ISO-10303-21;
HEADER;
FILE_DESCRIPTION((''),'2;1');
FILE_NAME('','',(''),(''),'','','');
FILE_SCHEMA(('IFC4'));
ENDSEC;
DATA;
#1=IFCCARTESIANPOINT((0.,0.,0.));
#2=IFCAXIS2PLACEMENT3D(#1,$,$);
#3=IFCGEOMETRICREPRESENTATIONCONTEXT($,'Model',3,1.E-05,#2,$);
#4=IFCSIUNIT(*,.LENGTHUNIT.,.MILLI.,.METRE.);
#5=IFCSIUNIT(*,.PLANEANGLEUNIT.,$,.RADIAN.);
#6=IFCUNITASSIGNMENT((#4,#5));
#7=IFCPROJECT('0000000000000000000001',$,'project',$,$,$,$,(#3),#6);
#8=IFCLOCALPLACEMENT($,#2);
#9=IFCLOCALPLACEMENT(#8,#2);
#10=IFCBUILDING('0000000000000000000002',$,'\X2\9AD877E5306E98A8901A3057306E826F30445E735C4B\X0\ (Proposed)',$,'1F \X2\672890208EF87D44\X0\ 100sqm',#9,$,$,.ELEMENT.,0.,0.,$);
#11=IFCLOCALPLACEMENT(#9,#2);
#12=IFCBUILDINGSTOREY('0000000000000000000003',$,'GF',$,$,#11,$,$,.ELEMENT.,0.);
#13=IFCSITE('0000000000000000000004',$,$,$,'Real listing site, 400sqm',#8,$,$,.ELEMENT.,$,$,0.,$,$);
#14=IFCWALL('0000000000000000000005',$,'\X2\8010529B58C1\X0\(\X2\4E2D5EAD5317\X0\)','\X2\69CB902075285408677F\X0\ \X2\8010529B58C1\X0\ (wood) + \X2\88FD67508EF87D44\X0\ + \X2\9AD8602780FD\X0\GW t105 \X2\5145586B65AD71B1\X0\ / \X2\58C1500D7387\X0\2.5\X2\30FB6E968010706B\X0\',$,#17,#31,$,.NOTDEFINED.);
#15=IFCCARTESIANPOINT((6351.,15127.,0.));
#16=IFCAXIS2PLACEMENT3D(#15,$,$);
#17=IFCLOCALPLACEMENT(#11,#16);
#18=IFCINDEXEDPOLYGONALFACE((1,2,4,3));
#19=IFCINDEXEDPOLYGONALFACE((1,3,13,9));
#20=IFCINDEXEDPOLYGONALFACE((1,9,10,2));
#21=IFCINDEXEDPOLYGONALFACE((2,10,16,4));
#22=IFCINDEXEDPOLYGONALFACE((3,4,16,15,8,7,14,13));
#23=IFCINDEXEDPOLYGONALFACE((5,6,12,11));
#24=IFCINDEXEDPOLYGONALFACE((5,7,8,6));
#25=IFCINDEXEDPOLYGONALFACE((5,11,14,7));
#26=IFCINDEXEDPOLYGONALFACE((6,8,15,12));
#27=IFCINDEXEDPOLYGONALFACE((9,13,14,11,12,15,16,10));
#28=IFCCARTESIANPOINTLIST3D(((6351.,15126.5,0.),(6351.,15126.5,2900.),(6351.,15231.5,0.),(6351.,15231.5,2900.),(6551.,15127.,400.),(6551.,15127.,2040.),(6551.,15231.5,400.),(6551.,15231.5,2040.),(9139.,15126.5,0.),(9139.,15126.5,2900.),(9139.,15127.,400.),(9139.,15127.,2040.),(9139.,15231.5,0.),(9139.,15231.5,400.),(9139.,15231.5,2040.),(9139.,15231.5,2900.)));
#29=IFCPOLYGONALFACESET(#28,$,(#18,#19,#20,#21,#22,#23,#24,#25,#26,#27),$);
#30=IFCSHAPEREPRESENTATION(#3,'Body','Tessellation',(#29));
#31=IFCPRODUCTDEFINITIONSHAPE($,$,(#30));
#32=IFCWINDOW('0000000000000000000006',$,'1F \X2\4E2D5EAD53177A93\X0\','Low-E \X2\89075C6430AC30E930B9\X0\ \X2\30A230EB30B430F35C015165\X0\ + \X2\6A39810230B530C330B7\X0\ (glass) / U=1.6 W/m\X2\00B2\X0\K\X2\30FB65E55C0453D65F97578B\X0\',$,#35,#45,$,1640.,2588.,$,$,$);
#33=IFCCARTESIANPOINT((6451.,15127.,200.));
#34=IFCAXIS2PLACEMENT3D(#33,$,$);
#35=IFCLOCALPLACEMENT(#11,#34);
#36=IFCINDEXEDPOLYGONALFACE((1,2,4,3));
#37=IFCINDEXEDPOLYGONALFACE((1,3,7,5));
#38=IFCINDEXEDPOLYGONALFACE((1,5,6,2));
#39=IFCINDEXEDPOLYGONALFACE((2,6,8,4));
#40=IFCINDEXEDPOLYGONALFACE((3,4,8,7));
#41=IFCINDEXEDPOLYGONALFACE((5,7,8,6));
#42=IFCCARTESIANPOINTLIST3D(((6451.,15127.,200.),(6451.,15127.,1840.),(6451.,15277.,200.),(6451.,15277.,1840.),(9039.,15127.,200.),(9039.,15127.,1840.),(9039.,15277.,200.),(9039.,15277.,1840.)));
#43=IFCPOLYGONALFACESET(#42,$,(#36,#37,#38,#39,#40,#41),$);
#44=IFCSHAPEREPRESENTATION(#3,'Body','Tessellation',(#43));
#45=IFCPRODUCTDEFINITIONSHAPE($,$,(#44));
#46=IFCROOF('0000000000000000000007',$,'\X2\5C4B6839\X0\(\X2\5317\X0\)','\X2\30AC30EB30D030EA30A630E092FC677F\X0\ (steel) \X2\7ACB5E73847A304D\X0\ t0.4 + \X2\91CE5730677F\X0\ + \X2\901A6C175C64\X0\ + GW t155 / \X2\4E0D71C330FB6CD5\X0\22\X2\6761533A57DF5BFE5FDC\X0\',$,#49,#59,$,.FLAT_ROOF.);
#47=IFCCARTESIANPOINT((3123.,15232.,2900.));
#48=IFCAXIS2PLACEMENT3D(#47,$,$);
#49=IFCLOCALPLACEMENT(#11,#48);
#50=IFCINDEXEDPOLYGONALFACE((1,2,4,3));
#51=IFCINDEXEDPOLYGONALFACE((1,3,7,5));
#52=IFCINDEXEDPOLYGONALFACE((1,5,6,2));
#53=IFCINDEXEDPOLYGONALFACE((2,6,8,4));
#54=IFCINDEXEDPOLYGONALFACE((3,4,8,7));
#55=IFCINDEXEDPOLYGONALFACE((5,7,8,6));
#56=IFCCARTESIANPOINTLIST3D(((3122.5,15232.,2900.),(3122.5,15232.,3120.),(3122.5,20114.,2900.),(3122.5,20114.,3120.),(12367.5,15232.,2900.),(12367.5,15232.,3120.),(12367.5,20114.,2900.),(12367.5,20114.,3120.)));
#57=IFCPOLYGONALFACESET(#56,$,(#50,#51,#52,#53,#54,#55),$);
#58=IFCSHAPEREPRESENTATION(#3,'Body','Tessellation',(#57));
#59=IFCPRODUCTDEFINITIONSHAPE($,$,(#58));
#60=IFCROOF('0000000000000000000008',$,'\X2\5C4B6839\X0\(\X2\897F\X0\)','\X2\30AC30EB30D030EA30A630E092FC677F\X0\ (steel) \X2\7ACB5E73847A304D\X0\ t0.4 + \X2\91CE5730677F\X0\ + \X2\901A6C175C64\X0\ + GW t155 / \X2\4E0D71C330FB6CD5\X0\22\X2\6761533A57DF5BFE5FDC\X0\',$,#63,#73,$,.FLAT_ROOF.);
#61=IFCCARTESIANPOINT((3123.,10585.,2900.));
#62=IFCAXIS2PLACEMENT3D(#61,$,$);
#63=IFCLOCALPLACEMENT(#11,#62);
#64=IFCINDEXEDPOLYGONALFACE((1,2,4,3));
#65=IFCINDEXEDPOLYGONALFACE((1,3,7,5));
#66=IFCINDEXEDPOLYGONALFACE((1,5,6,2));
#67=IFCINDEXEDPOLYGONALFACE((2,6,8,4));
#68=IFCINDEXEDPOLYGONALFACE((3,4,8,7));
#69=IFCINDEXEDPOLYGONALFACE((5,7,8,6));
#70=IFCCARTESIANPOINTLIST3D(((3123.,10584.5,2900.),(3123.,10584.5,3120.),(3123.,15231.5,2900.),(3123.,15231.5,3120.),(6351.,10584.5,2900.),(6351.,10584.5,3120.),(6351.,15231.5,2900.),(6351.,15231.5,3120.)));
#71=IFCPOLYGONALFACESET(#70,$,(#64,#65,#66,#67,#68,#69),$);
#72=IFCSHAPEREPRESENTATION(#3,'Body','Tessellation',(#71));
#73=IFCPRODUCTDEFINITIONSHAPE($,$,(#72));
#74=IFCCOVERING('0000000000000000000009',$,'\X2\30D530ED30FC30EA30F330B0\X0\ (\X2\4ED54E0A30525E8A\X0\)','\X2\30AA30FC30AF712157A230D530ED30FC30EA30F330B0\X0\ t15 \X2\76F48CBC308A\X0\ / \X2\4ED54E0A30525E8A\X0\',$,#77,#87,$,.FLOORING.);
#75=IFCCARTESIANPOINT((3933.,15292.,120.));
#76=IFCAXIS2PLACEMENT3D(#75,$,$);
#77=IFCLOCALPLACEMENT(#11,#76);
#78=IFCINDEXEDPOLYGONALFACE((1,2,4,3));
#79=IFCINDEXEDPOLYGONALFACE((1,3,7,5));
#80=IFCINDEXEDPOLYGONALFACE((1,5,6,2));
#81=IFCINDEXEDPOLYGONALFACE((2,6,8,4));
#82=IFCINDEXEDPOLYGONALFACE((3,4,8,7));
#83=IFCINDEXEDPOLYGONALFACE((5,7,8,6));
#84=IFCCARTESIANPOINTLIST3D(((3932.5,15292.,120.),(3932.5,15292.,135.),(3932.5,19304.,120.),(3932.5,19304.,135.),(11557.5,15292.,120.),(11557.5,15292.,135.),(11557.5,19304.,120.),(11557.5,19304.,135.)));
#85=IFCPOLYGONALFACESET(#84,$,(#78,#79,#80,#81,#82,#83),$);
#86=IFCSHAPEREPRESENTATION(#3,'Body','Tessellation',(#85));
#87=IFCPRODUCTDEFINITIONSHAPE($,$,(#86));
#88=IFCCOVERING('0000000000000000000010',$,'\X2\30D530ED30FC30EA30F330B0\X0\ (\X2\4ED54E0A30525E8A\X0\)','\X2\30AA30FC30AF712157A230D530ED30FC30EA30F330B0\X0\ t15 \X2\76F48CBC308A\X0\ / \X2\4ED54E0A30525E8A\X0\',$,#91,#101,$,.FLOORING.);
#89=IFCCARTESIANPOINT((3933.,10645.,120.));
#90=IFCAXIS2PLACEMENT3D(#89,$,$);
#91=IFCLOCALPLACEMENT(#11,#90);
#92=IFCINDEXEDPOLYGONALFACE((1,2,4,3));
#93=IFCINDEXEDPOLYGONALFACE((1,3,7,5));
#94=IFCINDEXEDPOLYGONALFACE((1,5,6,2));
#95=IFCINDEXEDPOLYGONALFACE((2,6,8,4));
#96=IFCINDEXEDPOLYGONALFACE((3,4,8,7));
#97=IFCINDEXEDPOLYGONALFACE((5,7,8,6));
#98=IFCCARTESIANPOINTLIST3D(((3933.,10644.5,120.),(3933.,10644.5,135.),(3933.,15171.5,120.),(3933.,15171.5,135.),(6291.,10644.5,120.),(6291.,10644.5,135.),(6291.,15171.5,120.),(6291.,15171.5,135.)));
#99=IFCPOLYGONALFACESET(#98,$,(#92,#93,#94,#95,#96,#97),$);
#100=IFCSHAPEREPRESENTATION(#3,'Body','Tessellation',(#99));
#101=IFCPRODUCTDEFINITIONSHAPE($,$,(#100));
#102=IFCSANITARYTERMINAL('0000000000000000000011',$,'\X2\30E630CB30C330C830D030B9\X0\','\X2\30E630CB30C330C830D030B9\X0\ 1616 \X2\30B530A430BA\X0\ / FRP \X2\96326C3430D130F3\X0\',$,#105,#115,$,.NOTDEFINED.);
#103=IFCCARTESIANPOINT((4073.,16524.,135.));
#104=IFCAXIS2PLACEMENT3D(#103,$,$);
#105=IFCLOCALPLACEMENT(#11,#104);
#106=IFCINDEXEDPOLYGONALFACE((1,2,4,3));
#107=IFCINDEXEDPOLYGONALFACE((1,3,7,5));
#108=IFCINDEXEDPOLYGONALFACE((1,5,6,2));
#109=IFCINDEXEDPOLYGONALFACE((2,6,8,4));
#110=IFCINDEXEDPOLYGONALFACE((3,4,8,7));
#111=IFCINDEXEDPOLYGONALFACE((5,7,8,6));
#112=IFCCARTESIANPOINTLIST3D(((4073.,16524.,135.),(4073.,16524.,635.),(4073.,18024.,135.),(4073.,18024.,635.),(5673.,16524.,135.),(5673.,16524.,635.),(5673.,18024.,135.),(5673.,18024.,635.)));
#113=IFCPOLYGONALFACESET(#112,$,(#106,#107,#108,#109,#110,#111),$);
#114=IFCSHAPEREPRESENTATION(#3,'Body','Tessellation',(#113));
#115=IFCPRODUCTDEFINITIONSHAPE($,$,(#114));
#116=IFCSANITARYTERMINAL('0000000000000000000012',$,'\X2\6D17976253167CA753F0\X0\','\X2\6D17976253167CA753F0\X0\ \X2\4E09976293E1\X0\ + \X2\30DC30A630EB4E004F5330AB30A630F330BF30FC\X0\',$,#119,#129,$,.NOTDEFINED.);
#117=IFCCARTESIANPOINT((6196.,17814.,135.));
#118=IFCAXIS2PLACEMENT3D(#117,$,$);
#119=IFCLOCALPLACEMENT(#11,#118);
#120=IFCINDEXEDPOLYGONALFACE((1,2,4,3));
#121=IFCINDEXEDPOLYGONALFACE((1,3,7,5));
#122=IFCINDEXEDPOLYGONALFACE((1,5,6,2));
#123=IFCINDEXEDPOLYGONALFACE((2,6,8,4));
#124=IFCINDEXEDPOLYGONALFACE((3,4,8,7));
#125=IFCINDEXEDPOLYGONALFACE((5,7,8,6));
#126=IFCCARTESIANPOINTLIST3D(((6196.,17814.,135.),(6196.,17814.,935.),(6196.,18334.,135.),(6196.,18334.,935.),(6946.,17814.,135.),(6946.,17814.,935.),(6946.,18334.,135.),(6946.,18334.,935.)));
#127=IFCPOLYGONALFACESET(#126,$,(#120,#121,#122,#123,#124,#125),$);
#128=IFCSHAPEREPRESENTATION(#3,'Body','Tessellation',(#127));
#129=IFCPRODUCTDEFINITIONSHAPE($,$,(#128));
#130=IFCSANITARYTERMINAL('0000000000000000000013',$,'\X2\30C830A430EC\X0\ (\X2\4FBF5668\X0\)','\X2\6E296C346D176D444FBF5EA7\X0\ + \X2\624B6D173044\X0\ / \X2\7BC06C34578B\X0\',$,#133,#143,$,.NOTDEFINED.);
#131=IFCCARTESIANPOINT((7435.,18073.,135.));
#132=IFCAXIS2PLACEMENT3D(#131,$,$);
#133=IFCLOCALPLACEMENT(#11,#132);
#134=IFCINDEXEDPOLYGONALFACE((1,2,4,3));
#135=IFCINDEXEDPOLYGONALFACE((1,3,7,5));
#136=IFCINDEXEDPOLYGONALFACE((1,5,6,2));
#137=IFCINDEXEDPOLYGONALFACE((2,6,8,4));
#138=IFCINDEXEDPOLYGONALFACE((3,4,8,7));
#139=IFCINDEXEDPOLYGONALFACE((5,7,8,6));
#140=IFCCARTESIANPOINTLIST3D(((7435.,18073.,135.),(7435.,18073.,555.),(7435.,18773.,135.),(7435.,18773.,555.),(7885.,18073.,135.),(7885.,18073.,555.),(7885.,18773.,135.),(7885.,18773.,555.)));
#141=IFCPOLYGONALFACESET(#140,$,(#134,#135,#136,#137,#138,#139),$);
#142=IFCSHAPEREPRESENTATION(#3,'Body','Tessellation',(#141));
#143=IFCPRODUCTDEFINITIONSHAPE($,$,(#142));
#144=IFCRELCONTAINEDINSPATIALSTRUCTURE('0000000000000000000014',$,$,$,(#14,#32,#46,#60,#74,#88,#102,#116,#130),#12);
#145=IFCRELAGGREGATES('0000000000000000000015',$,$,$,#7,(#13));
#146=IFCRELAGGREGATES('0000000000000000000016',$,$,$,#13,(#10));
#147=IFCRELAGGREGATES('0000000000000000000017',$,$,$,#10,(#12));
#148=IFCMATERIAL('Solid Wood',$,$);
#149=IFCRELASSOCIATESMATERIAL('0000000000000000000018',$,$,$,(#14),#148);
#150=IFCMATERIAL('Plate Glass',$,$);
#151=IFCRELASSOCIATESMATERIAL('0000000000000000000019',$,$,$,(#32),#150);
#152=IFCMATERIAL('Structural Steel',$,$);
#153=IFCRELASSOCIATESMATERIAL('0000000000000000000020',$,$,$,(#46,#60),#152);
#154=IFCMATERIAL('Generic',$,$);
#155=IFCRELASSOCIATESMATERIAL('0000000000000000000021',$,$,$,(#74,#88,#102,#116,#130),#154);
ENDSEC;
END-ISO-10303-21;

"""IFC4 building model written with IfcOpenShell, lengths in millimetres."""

from ifc_helpers import new_model, si_unit, frame, frame_2d, origin, place, context, project, spatial, rectangle, extrude, material, element, fill, save


model = new_model("IFC4")

# Units and contexts
model_context = context("Model", 3, precision=1e-05, world=origin())
ifc_project = project(units=[si_unit("LENGTHUNIT", "METRE", prefix="MILLI"), si_unit("PLANEANGLEUNIT", "RADIAN")], contexts=[model_context])

# Site, building, storey
site_placement = place(None, origin())
site = spatial("IfcSite", under=ifc_project, at=site_placement, ObjectType="Real listing site, 400sqm", CompositionType="ELEMENT", RefElevation=0.0)
building_placement = place(site_placement, origin())
building = spatial("IfcBuilding", under=site, at=building_placement, Name="高知の風通しの良い平屋 (Proposed)", ObjectType="1F 木造軸組 100sqm", CompositionType="ELEMENT", ElevationOfRefHeight=0.0, ElevationOfTerrain=0.0)
storey_placement = place(building_placement, origin())
storey = spatial("IfcBuildingStorey", under=building, at=storey_placement, Name="GF", CompositionType="ELEMENT", Elevation=0.0)

# Shared definitions
ifc_material_1 = material(Name="Solid Wood")

# Wall, opening, window
wall_1_placement = place(storey_placement, frame((6351.0, 15127.0, 0.0)))
wall_1 = element("IfcWall", 1, at=wall_1_placement, inside=storey, material=ifc_material_1, Name="耐力壁(中庭北)", Description="構造用合板 耐力壁 (wood) + 製材軸組 + 高性能GW t105 充填断熱 / 壁倍率2.5・準耐火", PredefinedType="NOTDEFINED", context=model_context, shape_type="SweptSolid", body=[
    extrude(rectangle(XDim=2788.0, YDim=105.0, at=frame_2d((1394.0, 52.0))), frame((6351.0, 15127.0, 0.0)), (0.0, 0.0, 1.0), 2900.0),
])
opening_placement = place(storey_placement, frame((6451.0, 15127.0, 200.0)))
opening = element("IfcOpeningElement", 2, at=opening_placement, cuts=wall_1, PredefinedType="NOTDEFINED", context=model_context, shape_type="SweptSolid", body=[
    extrude(rectangle(XDim=2588.0, YDim=150.0, at=frame_2d((1294.0, 75.0))), frame((6451.0, 15127.0, 200.0)), (0.0, 0.0, 1.0), 1640.0),
])
ifc_material_2 = material(Name="Plate Glass")
window_placement = place(storey_placement, frame((6451.0, 15127.0, 200.0)))
window = element("IfcWindow", 3, at=window_placement, inside=storey, material=ifc_material_2, Name="1F 中庭北窓", Description="Low-E 複層ガラス アルゴン封入 + 樹脂サッシ (glass) / U=1.6 W/m²K・日射取得型", OverallHeight=1640.0, OverallWidth=2588.0, context=model_context, shape_type="SweptSolid", body=[
    extrude(rectangle(XDim=2588.0, YDim=150.0, at=frame_2d((1294.0, 75.0))), frame((6451.0, 15127.0, 200.0)), (0.0, 0.0, 1.0), 1640.0),
])
fill(opening, window)

# Roofs
ifc_material_3 = material(Name="Structural Steel")
roof_1_placement = place(storey_placement, frame((3123.0, 15232.0, 2900.0)))
element("IfcRoof", 4, at=roof_1_placement, inside=storey, material=ifc_material_3, Name="屋根(北)", Description="ガルバリウム鋼板 (steel) 立平葺き t0.4 + 野地板 + 通気層 + GW t155 / 不燃・法22条区域対応", PredefinedType="FLAT_ROOF", context=model_context, shape_type="SweptSolid", body=[
    extrude(rectangle(XDim=9245.0, YDim=4882.0, at=frame_2d((4622.0, 2441.0))), frame((3123.0, 15232.0, 2900.0)), (0.0, 0.0, 1.0), 220.0),
])
roof_2_placement = place(storey_placement, frame((3123.0, 10585.0, 2900.0)))
element("IfcRoof", 5, at=roof_2_placement, inside=storey, material=ifc_material_3, Name="屋根(西)", Description="ガルバリウム鋼板 (steel) 立平葺き t0.4 + 野地板 + 通気層 + GW t155 / 不燃・法22条区域対応", PredefinedType="FLAT_ROOF", context=model_context, shape_type="SweptSolid", body=[
    extrude(rectangle(XDim=3228.0, YDim=4647.0, at=frame_2d((1614.0, 2323.0))), frame((3123.0, 10585.0, 2900.0)), (0.0, 0.0, 1.0), 220.0),
])

# Coverings
ifc_material_4 = material(Name="Generic")
covering_1_placement = place(storey_placement, frame((3933.0, 15292.0, 120.0)))
element("IfcCovering", 6, at=covering_1_placement, inside=storey, material=ifc_material_4, Name="フローリング (仕上げ床)", Description="オーク無垢フローリング t15 直貼り / 仕上げ床", PredefinedType="FLOORING", context=model_context, shape_type="SweptSolid", body=[
    extrude(rectangle(XDim=7625.0, YDim=4012.0, at=frame_2d((3812.0, 2006.0))), frame((3933.0, 15292.0, 120.0)), (0.0, 0.0, 1.0), 15.0),
])
covering_2_placement = place(storey_placement, frame((3933.0, 10645.0, 120.0)))
element("IfcCovering", 7, at=covering_2_placement, inside=storey, material=ifc_material_4, Name="フローリング (仕上げ床)", Description="オーク無垢フローリング t15 直貼り / 仕上げ床", PredefinedType="FLOORING", context=model_context, shape_type="SweptSolid", body=[
    extrude(rectangle(XDim=2358.0, YDim=4527.0, at=frame_2d((1179.0, 2263.0))), frame((3933.0, 10645.0, 120.0)), (0.0, 0.0, 1.0), 15.0),
])

# Sanitary terminals
sanitary_terminal_1_placement = place(storey_placement, frame((4073.0, 16524.0, 135.0)))
element("IfcSanitaryTerminal", 8, at=sanitary_terminal_1_placement, inside=storey, material=ifc_material_4, Name="ユニットバス", Description="ユニットバス 1616 サイズ / FRP 防水パン", PredefinedType="NOTDEFINED", context=model_context, shape_type="SweptSolid", body=[
    extrude(rectangle(XDim=1600.0, YDim=1500.0, at=frame_2d((800.0, 750.0))), frame((4073.0, 16524.0, 135.0)), (0.0, 0.0, 1.0), 500.0),
])
sanitary_terminal_2_placement = place(storey_placement, frame((6196.0, 17814.0, 135.0)))
element("IfcSanitaryTerminal", 9, at=sanitary_terminal_2_placement, inside=storey, material=ifc_material_4, Name="洗面化粧台", Description="洗面化粧台 三面鏡 + ボウル一体カウンター", PredefinedType="NOTDEFINED", context=model_context, shape_type="SweptSolid", body=[
    extrude(rectangle(XDim=750.0, YDim=520.0, at=frame_2d((375.0, 260.0))), frame((6196.0, 17814.0, 135.0)), (0.0, 0.0, 1.0), 800.0),
])
sanitary_terminal_3_placement = place(storey_placement, frame((7435.0, 18073.0, 135.0)))
element("IfcSanitaryTerminal", 10, at=sanitary_terminal_3_placement, inside=storey, material=ifc_material_4, Name="トイレ (便器)", Description="温水洗浄便座 + 手洗い / 節水型", PredefinedType="NOTDEFINED", context=model_context, shape_type="SweptSolid", body=[
    extrude(rectangle(XDim=450.0, YDim=700.0, at=frame_2d((225.0, 350.0))), frame((7435.0, 18073.0, 135.0)), (0.0, 0.0, 1.0), 420.0),
])

save(model, "model.ifc")
